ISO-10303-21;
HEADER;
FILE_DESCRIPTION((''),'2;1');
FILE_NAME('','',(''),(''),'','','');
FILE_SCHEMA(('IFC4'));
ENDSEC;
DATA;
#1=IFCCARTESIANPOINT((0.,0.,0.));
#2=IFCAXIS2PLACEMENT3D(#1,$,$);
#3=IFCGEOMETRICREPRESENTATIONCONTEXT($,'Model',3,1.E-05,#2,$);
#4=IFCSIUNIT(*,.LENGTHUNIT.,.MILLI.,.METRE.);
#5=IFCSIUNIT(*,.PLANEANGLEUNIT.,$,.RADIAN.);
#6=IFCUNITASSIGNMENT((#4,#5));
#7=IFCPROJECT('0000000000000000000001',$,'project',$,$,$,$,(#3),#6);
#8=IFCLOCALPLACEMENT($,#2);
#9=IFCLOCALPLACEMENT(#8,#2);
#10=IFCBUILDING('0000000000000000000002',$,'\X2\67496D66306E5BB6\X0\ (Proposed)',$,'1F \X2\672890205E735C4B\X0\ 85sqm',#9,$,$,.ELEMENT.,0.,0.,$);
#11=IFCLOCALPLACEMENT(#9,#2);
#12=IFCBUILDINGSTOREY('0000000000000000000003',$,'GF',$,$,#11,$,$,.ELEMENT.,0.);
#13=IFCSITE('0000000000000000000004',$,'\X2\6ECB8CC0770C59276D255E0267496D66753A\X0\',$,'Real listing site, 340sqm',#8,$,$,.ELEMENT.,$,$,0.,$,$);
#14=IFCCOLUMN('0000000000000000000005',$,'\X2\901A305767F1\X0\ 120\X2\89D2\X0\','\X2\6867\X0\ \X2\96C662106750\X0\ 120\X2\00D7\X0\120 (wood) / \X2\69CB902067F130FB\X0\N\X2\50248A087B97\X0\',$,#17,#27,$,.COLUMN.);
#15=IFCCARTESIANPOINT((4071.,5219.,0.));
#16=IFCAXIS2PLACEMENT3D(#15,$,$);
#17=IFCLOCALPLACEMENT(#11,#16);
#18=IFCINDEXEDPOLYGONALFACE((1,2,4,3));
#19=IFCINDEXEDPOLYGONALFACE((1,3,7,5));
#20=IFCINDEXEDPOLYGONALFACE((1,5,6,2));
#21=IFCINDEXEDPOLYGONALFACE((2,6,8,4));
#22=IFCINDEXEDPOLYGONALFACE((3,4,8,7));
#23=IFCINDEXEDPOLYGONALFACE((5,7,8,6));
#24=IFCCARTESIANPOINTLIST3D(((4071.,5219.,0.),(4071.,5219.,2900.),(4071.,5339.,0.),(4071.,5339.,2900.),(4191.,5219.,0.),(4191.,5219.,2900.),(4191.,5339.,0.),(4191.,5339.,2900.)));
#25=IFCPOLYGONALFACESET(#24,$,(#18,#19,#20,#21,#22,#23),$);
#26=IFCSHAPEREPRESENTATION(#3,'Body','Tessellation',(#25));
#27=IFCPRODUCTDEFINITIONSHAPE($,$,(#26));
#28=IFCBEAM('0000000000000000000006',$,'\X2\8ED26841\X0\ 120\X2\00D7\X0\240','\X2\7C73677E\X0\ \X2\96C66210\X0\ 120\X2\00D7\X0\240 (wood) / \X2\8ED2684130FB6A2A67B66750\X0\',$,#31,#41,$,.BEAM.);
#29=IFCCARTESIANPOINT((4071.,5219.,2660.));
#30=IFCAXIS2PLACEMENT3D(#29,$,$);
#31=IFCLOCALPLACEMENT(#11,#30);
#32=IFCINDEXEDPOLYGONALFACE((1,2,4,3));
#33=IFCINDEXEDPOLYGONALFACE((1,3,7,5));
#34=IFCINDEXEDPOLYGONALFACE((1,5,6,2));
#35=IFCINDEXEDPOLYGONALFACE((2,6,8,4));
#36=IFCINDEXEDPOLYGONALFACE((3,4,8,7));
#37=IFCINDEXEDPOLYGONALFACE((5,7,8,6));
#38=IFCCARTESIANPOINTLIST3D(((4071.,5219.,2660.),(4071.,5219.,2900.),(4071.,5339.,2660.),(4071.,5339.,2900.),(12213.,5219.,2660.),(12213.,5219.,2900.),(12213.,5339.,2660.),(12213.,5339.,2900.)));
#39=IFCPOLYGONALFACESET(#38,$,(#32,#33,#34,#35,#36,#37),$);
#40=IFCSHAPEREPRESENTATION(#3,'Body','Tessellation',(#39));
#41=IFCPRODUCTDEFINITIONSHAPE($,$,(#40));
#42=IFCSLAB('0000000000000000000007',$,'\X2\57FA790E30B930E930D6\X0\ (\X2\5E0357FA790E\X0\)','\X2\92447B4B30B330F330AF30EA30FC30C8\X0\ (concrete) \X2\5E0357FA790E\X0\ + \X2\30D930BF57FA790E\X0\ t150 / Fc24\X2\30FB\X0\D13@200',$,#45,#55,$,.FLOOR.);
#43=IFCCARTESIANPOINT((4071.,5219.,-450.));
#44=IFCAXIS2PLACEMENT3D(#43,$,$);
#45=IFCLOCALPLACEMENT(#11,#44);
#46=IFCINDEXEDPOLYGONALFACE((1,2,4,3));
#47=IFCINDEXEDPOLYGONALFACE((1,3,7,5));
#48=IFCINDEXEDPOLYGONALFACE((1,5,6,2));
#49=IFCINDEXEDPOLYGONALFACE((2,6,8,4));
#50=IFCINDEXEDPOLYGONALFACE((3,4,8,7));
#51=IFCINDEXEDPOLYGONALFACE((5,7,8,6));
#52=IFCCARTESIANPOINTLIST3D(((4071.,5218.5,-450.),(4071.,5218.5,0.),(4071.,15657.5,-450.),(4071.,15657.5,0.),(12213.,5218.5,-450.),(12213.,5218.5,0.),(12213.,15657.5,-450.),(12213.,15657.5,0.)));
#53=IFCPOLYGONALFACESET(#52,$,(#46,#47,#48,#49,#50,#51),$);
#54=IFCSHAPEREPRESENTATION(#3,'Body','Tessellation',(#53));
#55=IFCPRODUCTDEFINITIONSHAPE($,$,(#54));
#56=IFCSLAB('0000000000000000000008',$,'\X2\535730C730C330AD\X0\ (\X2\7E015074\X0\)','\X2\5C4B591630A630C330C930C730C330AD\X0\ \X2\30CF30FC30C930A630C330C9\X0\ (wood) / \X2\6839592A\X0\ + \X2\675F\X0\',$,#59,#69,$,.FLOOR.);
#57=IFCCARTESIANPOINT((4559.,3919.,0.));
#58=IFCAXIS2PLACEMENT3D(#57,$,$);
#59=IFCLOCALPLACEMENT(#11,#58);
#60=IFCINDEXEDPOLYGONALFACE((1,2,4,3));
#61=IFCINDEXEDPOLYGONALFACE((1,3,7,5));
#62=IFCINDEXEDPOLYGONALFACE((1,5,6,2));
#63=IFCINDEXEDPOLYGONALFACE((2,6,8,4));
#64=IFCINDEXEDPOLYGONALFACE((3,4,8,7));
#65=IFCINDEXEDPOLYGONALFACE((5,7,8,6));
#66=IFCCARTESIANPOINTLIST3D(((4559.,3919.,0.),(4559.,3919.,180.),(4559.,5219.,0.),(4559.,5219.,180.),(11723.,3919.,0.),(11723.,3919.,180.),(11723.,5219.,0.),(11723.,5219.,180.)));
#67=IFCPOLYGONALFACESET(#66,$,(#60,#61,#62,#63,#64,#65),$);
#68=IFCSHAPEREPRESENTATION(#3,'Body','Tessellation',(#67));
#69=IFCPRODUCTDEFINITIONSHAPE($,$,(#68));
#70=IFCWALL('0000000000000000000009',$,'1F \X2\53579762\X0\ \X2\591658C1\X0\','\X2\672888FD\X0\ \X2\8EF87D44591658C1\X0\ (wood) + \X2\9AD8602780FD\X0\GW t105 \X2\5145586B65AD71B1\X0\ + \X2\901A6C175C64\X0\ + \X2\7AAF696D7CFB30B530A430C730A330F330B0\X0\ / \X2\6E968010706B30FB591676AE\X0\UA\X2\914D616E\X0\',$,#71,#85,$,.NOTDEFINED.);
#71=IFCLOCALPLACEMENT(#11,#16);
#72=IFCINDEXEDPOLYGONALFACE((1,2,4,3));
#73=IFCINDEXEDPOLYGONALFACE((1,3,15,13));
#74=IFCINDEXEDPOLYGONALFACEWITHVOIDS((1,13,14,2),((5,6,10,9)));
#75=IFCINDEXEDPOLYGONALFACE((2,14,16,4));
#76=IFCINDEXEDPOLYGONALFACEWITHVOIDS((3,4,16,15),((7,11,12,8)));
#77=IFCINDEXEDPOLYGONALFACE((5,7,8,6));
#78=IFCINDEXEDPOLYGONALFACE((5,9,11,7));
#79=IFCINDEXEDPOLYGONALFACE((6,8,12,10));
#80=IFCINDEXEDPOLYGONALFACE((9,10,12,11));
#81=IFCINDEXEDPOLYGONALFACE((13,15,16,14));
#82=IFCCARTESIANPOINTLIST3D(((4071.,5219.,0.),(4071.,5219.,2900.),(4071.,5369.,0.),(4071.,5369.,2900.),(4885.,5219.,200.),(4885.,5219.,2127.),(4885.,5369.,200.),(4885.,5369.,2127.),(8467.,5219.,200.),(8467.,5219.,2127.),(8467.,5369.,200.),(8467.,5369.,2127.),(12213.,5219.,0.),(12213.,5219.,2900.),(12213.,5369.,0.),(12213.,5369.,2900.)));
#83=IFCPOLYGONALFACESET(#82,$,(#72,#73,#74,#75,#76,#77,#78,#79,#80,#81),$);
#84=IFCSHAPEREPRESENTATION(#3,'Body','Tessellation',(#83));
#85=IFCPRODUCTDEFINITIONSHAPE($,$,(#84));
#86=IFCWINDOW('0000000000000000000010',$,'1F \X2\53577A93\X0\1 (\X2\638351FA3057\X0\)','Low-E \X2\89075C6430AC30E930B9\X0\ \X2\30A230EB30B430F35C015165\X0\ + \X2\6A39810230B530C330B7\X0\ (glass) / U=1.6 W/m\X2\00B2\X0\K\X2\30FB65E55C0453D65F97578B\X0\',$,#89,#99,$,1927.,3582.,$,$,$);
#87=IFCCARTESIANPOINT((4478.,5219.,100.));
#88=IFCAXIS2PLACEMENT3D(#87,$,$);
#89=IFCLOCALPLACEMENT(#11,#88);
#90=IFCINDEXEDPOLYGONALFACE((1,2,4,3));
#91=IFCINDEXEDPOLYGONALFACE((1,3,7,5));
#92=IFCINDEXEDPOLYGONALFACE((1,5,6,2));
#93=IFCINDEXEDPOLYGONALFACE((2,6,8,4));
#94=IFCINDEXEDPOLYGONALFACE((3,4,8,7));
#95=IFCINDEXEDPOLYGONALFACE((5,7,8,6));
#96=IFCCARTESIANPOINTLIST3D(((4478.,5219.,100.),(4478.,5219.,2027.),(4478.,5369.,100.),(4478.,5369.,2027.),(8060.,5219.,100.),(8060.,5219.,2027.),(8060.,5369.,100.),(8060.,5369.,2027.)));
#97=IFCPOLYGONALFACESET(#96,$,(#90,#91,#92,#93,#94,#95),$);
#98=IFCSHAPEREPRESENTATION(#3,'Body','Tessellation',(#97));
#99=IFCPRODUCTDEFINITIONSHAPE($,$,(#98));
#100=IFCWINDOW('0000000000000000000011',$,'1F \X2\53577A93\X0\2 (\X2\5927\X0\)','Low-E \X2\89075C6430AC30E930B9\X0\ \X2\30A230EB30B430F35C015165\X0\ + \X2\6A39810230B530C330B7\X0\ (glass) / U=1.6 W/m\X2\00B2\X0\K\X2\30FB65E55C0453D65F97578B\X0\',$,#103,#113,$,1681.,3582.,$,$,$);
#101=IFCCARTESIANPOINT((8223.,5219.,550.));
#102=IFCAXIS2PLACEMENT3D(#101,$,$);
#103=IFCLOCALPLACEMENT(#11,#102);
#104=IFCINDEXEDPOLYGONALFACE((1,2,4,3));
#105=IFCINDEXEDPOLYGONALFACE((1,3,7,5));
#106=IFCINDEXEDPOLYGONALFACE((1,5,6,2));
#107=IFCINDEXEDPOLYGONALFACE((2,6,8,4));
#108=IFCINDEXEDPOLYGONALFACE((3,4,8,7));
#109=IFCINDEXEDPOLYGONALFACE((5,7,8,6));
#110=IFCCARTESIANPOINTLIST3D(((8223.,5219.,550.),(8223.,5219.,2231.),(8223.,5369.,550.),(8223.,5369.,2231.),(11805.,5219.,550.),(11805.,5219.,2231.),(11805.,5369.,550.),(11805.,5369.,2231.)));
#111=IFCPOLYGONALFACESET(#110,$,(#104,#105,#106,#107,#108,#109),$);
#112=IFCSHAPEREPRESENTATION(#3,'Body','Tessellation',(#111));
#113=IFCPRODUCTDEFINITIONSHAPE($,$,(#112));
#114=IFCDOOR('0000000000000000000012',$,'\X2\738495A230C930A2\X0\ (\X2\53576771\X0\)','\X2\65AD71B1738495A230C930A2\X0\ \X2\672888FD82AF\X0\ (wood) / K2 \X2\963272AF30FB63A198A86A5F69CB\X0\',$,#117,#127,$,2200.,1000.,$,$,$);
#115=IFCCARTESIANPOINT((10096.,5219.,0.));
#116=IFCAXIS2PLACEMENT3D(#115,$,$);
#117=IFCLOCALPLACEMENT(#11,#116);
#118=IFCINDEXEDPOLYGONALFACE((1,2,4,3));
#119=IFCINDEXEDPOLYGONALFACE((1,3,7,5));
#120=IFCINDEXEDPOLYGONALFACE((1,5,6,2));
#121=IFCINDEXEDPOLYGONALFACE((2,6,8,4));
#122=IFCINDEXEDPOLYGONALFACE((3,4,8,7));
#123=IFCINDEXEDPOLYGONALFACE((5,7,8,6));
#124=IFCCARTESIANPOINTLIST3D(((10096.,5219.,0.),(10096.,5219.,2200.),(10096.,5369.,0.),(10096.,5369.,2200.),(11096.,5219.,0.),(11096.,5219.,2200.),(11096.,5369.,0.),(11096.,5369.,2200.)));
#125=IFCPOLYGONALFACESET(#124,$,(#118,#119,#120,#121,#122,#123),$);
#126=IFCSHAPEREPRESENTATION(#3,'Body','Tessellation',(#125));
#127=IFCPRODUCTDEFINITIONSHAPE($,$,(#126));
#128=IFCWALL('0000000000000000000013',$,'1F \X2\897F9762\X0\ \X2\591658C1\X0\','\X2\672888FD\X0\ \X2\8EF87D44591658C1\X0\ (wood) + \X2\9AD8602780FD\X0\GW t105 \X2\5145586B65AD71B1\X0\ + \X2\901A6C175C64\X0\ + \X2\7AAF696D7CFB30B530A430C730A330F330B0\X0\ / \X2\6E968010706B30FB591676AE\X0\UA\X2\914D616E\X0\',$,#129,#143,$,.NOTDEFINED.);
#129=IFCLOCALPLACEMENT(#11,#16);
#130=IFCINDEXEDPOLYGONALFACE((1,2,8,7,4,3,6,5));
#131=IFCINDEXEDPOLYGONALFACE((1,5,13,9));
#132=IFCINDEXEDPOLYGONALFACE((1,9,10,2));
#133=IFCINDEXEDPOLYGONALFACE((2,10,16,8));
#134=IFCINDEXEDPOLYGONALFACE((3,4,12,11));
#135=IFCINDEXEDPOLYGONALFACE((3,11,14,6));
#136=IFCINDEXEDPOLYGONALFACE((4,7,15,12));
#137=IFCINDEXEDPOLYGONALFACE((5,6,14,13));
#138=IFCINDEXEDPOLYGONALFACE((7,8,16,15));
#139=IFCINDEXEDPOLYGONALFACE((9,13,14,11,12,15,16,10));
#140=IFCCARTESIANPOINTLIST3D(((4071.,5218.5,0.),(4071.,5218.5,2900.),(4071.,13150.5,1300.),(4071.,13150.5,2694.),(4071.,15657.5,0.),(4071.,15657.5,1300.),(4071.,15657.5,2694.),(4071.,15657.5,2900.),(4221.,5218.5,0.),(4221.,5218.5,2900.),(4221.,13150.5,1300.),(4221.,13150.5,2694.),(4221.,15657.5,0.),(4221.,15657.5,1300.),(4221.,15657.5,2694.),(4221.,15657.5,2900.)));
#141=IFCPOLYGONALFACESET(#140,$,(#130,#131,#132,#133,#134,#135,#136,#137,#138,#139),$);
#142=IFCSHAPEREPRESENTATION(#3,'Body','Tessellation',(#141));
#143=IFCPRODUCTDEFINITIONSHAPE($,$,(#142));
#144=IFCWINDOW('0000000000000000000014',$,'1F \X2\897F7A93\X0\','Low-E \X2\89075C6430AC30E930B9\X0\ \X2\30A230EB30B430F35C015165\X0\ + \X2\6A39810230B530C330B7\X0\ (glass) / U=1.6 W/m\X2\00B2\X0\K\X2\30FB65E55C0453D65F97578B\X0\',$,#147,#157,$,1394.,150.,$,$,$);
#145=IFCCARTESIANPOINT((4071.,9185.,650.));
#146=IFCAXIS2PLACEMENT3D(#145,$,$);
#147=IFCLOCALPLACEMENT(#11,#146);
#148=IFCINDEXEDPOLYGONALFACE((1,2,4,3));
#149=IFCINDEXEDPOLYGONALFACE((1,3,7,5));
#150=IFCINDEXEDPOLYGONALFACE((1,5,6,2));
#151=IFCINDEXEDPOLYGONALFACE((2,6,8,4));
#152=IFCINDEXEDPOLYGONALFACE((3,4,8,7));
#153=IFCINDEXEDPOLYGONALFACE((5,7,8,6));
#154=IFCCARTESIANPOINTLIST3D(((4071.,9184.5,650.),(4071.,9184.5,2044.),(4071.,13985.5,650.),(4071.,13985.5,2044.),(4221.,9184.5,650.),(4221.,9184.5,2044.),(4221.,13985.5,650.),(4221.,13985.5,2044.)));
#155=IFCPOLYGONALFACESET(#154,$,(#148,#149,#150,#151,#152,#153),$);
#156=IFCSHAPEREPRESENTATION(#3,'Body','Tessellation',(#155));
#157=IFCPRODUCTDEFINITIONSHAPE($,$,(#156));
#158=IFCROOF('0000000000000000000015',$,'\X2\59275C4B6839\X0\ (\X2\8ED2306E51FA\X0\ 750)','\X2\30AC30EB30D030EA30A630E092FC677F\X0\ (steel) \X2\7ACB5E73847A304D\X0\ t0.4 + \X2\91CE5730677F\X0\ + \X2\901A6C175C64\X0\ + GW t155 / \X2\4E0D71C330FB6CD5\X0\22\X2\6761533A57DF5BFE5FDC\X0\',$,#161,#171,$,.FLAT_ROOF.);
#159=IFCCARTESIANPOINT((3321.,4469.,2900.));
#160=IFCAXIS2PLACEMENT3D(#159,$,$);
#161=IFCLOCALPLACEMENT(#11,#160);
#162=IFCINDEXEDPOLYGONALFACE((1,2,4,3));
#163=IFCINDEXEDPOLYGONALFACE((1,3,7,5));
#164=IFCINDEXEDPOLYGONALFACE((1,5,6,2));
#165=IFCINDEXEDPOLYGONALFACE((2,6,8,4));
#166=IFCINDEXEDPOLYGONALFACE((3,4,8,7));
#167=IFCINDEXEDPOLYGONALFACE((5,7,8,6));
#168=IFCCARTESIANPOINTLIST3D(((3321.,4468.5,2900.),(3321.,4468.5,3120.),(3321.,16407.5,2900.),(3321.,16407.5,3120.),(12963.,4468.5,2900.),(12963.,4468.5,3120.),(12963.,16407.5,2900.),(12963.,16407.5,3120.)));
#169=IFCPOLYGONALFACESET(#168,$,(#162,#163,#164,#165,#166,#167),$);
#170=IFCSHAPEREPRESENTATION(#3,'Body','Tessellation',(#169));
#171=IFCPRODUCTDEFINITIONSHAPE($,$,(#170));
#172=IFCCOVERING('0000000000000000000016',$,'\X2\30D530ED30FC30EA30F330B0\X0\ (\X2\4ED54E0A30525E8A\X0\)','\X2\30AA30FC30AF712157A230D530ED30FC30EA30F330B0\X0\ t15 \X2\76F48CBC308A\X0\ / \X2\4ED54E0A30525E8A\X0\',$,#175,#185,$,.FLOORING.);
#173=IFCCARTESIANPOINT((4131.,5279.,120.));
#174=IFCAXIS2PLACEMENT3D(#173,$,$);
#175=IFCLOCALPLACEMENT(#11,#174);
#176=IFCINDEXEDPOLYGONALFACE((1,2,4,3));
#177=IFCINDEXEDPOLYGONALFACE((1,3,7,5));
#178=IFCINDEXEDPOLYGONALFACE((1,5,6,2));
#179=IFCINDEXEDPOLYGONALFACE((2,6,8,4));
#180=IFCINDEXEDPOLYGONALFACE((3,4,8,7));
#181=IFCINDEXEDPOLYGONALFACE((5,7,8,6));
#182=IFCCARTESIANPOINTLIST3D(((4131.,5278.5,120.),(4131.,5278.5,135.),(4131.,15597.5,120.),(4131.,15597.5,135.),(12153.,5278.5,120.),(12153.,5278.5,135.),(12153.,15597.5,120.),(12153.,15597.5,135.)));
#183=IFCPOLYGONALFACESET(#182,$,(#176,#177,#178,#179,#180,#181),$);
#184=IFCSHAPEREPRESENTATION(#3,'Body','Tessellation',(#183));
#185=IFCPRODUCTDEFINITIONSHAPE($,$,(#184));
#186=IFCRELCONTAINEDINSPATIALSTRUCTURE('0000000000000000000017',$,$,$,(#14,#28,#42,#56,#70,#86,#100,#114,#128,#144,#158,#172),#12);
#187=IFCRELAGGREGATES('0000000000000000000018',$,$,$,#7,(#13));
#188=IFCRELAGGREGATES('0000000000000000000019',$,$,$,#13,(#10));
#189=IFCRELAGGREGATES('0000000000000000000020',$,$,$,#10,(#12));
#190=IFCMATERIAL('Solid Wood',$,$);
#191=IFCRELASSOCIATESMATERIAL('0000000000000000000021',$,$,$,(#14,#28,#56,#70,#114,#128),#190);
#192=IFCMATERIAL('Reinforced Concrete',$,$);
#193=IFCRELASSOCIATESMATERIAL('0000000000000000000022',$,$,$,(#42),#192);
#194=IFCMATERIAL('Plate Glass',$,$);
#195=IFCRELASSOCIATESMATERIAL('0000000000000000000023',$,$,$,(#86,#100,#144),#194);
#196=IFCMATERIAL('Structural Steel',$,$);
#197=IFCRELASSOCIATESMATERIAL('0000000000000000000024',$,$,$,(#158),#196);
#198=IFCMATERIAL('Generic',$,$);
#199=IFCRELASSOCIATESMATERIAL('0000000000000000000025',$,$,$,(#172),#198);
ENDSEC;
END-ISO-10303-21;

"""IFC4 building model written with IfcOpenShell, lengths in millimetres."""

from ifc_helpers import new_model, si_unit, frame, frame_2d, origin, place, context, project, spatial, rectangle, extrude, material, element, fill, save


model = new_model("IFC4")

# Units and contexts
model_context = context("Model", 3, precision=1e-05, world=origin())
ifc_project = project(units=[si_unit("LENGTHUNIT", "METRE", prefix="MILLI"), si_unit("PLANEANGLEUNIT", "RADIAN")], contexts=[model_context])

# Site, building, storey
site_placement = place(None, origin())
site = spatial("IfcSite", under=ifc_project, at=site_placement, Name="滋賀県大津市杉浦町", ObjectType="Real listing site, 340sqm", CompositionType="ELEMENT", RefElevation=0.0)
building_placement = place(site_placement, origin())
building = spatial("IfcBuilding", under=site, at=building_placement, Name="杉浦の家 (Proposed)", ObjectType="1F 木造平屋 85sqm", CompositionType="ELEMENT", ElevationOfRefHeight=0.0, ElevationOfTerrain=0.0)
storey_placement = place(building_placement, origin())
storey = spatial("IfcBuildingStorey", under=building, at=storey_placement, Name="GF", CompositionType="ELEMENT", Elevation=0.0)

# Column
ifc_material_1 = material(Name="Solid Wood")
column_1_placement = place(storey_placement, frame((4071.0, 5219.0, 0.0)))
element("IfcColumn", 1, at=column_1_placement, inside=storey, material=ifc_material_1, Name="通し柱 120角", Description="桧 集成材 120×120 (wood) / 構造柱・N値計算", PredefinedType="COLUMN", context=model_context, shape_type="SweptSolid", body=[
    extrude(rectangle(XDim=120.0, YDim=120.0, at=frame_2d((60.0, 60.0))), frame((4071.0, 5219.0, 0.0)), (0.0, 0.0, 1.0), 2900.0),
])

# Beam
beam_1_placement = place(storey_placement, frame((4071.0, 5219.0, 2660.0)))
element("IfcBeam", 2, at=beam_1_placement, inside=storey, material=ifc_material_1, Name="軒桁 120×240", Description="米松 集成 120×240 (wood) / 軒桁・横架材", PredefinedType="BEAM", context=model_context, shape_type="SweptSolid", body=[
    extrude(rectangle(XDim=8142.0, YDim=120.0, at=frame_2d((4071.0, 60.0))), frame((4071.0, 5219.0, 2660.0)), (0.0, 0.0, 1.0), 240.0),
])

# Slabs
ifc_material_2 = material(Name="Reinforced Concrete")
slab_1_placement = place(storey_placement, frame((4071.0, 5219.0, -450.0)))
element("IfcSlab", 3, at=slab_1_placement, inside=storey, material=ifc_material_2, Name="基礎スラブ (布基礎)", Description="鉄筋コンクリート (concrete) 布基礎 + ベタ基礎 t150 / Fc24・D13@200", PredefinedType="FLOOR", context=model_context, shape_type="SweptSolid", body=[
    extrude(rectangle(XDim=8142.0, YDim=10439.0, at=frame_2d((4071.0, 5219.0))), frame((4071.0, 5219.0, -450.0)), (0.0, 0.0, 1.0), 450.0),
])
slab_2_placement = place(storey_placement, frame((4559.0, 3919.0, 0.0)))
element("IfcSlab", 4, at=slab_2_placement, inside=storey, material=ifc_material_1, Name="南デッキ (縁側)", Description="屋外ウッドデッキ ハードウッド (wood) / 根太 + 束", PredefinedType="FLOOR", context=model_context, shape_type="SweptSolid", body=[
    extrude(rectangle(XDim=7164.0, YDim=1300.0, at=frame_2d((3582.0, 650.0))), frame((4559.0, 3919.0, 0.0)), (0.0, 0.0, 1.0), 180.0),
])

# Wall, openings, windows, door
wall_1_placement = place(storey_placement, frame((4071.0, 5219.0, 0.0)))
wall_1 = element("IfcWall", 5, at=wall_1_placement, inside=storey, material=ifc_material_1, Name="1F 南面 外壁", Description="木製 軸組外壁 (wood) + 高性能GW t105 充填断熱 + 通気層 + 窯業系サイディング / 準耐火・外皮UA配慮", PredefinedType="NOTDEFINED", context=model_context, shape_type="SweptSolid", body=[
    extrude(rectangle(XDim=8142.0, YDim=150.0, at=frame_2d((4071.0, 75.0))), frame((4071.0, 5219.0, 0.0)), (0.0, 0.0, 1.0), 2900.0),
])
opening_1_placement = place(storey_placement, frame((4478.0, 5219.0, 100.0)))
opening_1 = element("IfcOpeningElement", 6, at=opening_1_placement, cuts=wall_1, PredefinedType="NOTDEFINED", context=model_context, shape_type="SweptSolid", body=[
    extrude(rectangle(XDim=3582.0, YDim=150.0, at=frame_2d((1791.0, 75.0))), frame((4478.0, 5219.0, 100.0)), (0.0, 0.0, 1.0), 1927.0),
])
opening_2_placement = place(storey_placement, frame((8223.0, 5219.0, 550.0)))
opening_2 = element("IfcOpeningElement", 7, at=opening_2_placement, cuts=wall_1, PredefinedType="NOTDEFINED", context=model_context, shape_type="SweptSolid", body=[
    extrude(rectangle(XDim=3582.0, YDim=150.0, at=frame_2d((1791.0, 75.0))), frame((8223.0, 5219.0, 550.0)), (0.0, 0.0, 1.0), 1681.0),
])
opening_3_placement = place(storey_placement, frame((10096.0, 5219.0, 0.0)))
opening_3 = element("IfcOpeningElement", 8, at=opening_3_placement, cuts=wall_1, PredefinedType="NOTDEFINED", context=model_context, shape_type="SweptSolid", body=[
    extrude(rectangle(XDim=1000.0, YDim=150.0, at=frame_2d((500.0, 75.0))), frame((10096.0, 5219.0, 0.0)), (0.0, 0.0, 1.0), 2200.0),
])
ifc_material_3 = material(Name="Plate Glass")
window_1_placement = place(storey_placement, frame((4478.0, 5219.0, 100.0)))
window_1 = element("IfcWindow", 9, at=window_1_placement, inside=storey, material=ifc_material_3, Name="1F 南窓1 (掃出し)", Description="Low-E 複層ガラス アルゴン封入 + 樹脂サッシ (glass) / U=1.6 W/m²K・日射取得型", OverallHeight=1927.0, OverallWidth=3582.0, context=model_context, shape_type="SweptSolid", body=[
    extrude(rectangle(XDim=3582.0, YDim=150.0, at=frame_2d((1791.0, 75.0))), frame((4478.0, 5219.0, 100.0)), (0.0, 0.0, 1.0), 1927.0),
])
fill(opening_1, window_1)
window_2_placement = place(storey_placement, frame((8223.0, 5219.0, 550.0)))
window_2 = element("IfcWindow", 10, at=window_2_placement, inside=storey, material=ifc_material_3, Name="1F 南窓2 (大)", Description="Low-E 複層ガラス アルゴン封入 + 樹脂サッシ (glass) / U=1.6 W/m²K・日射取得型", OverallHeight=1681.0, OverallWidth=3582.0, context=model_context, shape_type="SweptSolid", body=[
    extrude(rectangle(XDim=3582.0, YDim=150.0, at=frame_2d((1791.0, 75.0))), frame((8223.0, 5219.0, 550.0)), (0.0, 0.0, 1.0), 1681.0),
])
fill(opening_2, window_2)
door_placement = place(storey_placement, frame((10096.0, 5219.0, 0.0)))
door = element("IfcDoor", 11, at=door_placement, inside=storey, material=ifc_material_1, Name="玄関ドア (南東)", Description="断熱玄関ドア 木製芯 (wood) / K2 防犯・採風機構", OverallHeight=2200.0, OverallWidth=1000.0, context=model_context, shape_type="SweptSolid", body=[
    extrude(rectangle(XDim=1000.0, YDim=150.0, at=frame_2d((500.0, 75.0))), frame((10096.0, 5219.0, 0.0)), (0.0, 0.0, 1.0), 2200.0),
])
fill(opening_3, door)

# Wall, opening, window
wall_2_placement = place(storey_placement, frame((4071.0, 5219.0, 0.0)))
wall_2 = element("IfcWall", 12, at=wall_2_placement, inside=storey, material=ifc_material_1, Name="1F 西面 外壁", Description="木製 軸組外壁 (wood) + 高性能GW t105 充填断熱 + 通気層 + 窯業系サイディング / 準耐火・外皮UA配慮", PredefinedType="NOTDEFINED", context=model_context, shape_type="SweptSolid", body=[
    extrude(rectangle(XDim=150.0, YDim=10439.0, at=frame_2d((75.0, 5219.0))), frame((4071.0, 5219.0, 0.0)), (0.0, 0.0, 1.0), 2900.0),
])
opening_4_placement = place(storey_placement, frame((4071.0, 9185.0, 650.0)))
opening_4 = element("IfcOpeningElement", 13, at=opening_4_placement, cuts=wall_2, PredefinedType="NOTDEFINED", context=model_context, shape_type="SweptSolid", body=[
    extrude(rectangle(XDim=150.0, YDim=4801.0, at=frame_2d((75.0, 2400.0))), frame((4071.0, 9185.0, 650.0)), (0.0, 0.0, 1.0), 1394.0),
])
window_3_placement = place(storey_placement, frame((4071.0, 9185.0, 650.0)))
window_3 = element("IfcWindow", 14, at=window_3_placement, inside=storey, material=ifc_material_3, Name="1F 西窓", Description="Low-E 複層ガラス アルゴン封入 + 樹脂サッシ (glass) / U=1.6 W/m²K・日射取得型", OverallHeight=1394.0, OverallWidth=150.0, context=model_context, shape_type="SweptSolid", body=[
    extrude(rectangle(XDim=150.0, YDim=4801.0, at=frame_2d((75.0, 2400.0))), frame((4071.0, 9185.0, 650.0)), (0.0, 0.0, 1.0), 1394.0),
])
fill(opening_4, window_3)

# Roof
ifc_material_4 = material(Name="Structural Steel")
roof_placement = place(storey_placement, frame((3321.0, 4469.0, 2900.0)))
element("IfcRoof", 15, at=roof_placement, inside=storey, material=ifc_material_4, Name="大屋根 (軒の出 750)", Description="ガルバリウム鋼板 (steel) 立平葺き t0.4 + 野地板 + 通気層 + GW t155 / 不燃・法22条区域対応", PredefinedType="FLAT_ROOF", context=model_context, shape_type="SweptSolid", body=[
    extrude(rectangle(XDim=9642.0, YDim=11939.0, at=frame_2d((4821.0, 5969.0))), frame((3321.0, 4469.0, 2900.0)), (0.0, 0.0, 1.0), 220.0),
])

# Covering
ifc_material_5 = material(Name="Generic")
covering_1_placement = place(storey_placement, frame((4131.0, 5279.0, 120.0)))
element("IfcCovering", 16, at=covering_1_placement, inside=storey, material=ifc_material_5, Name="フローリング (仕上げ床)", Description="オーク無垢フローリング t15 直貼り / 仕上げ床", PredefinedType="FLOORING", context=model_context, shape_type="SweptSolid", body=[
    extrude(rectangle(XDim=8022.0, YDim=10319.0, at=frame_2d((4011.0, 5159.0))), frame((4131.0, 5279.0, 120.0)), (0.0, 0.0, 1.0), 15.0),
])

save(model, "model.ifc")
